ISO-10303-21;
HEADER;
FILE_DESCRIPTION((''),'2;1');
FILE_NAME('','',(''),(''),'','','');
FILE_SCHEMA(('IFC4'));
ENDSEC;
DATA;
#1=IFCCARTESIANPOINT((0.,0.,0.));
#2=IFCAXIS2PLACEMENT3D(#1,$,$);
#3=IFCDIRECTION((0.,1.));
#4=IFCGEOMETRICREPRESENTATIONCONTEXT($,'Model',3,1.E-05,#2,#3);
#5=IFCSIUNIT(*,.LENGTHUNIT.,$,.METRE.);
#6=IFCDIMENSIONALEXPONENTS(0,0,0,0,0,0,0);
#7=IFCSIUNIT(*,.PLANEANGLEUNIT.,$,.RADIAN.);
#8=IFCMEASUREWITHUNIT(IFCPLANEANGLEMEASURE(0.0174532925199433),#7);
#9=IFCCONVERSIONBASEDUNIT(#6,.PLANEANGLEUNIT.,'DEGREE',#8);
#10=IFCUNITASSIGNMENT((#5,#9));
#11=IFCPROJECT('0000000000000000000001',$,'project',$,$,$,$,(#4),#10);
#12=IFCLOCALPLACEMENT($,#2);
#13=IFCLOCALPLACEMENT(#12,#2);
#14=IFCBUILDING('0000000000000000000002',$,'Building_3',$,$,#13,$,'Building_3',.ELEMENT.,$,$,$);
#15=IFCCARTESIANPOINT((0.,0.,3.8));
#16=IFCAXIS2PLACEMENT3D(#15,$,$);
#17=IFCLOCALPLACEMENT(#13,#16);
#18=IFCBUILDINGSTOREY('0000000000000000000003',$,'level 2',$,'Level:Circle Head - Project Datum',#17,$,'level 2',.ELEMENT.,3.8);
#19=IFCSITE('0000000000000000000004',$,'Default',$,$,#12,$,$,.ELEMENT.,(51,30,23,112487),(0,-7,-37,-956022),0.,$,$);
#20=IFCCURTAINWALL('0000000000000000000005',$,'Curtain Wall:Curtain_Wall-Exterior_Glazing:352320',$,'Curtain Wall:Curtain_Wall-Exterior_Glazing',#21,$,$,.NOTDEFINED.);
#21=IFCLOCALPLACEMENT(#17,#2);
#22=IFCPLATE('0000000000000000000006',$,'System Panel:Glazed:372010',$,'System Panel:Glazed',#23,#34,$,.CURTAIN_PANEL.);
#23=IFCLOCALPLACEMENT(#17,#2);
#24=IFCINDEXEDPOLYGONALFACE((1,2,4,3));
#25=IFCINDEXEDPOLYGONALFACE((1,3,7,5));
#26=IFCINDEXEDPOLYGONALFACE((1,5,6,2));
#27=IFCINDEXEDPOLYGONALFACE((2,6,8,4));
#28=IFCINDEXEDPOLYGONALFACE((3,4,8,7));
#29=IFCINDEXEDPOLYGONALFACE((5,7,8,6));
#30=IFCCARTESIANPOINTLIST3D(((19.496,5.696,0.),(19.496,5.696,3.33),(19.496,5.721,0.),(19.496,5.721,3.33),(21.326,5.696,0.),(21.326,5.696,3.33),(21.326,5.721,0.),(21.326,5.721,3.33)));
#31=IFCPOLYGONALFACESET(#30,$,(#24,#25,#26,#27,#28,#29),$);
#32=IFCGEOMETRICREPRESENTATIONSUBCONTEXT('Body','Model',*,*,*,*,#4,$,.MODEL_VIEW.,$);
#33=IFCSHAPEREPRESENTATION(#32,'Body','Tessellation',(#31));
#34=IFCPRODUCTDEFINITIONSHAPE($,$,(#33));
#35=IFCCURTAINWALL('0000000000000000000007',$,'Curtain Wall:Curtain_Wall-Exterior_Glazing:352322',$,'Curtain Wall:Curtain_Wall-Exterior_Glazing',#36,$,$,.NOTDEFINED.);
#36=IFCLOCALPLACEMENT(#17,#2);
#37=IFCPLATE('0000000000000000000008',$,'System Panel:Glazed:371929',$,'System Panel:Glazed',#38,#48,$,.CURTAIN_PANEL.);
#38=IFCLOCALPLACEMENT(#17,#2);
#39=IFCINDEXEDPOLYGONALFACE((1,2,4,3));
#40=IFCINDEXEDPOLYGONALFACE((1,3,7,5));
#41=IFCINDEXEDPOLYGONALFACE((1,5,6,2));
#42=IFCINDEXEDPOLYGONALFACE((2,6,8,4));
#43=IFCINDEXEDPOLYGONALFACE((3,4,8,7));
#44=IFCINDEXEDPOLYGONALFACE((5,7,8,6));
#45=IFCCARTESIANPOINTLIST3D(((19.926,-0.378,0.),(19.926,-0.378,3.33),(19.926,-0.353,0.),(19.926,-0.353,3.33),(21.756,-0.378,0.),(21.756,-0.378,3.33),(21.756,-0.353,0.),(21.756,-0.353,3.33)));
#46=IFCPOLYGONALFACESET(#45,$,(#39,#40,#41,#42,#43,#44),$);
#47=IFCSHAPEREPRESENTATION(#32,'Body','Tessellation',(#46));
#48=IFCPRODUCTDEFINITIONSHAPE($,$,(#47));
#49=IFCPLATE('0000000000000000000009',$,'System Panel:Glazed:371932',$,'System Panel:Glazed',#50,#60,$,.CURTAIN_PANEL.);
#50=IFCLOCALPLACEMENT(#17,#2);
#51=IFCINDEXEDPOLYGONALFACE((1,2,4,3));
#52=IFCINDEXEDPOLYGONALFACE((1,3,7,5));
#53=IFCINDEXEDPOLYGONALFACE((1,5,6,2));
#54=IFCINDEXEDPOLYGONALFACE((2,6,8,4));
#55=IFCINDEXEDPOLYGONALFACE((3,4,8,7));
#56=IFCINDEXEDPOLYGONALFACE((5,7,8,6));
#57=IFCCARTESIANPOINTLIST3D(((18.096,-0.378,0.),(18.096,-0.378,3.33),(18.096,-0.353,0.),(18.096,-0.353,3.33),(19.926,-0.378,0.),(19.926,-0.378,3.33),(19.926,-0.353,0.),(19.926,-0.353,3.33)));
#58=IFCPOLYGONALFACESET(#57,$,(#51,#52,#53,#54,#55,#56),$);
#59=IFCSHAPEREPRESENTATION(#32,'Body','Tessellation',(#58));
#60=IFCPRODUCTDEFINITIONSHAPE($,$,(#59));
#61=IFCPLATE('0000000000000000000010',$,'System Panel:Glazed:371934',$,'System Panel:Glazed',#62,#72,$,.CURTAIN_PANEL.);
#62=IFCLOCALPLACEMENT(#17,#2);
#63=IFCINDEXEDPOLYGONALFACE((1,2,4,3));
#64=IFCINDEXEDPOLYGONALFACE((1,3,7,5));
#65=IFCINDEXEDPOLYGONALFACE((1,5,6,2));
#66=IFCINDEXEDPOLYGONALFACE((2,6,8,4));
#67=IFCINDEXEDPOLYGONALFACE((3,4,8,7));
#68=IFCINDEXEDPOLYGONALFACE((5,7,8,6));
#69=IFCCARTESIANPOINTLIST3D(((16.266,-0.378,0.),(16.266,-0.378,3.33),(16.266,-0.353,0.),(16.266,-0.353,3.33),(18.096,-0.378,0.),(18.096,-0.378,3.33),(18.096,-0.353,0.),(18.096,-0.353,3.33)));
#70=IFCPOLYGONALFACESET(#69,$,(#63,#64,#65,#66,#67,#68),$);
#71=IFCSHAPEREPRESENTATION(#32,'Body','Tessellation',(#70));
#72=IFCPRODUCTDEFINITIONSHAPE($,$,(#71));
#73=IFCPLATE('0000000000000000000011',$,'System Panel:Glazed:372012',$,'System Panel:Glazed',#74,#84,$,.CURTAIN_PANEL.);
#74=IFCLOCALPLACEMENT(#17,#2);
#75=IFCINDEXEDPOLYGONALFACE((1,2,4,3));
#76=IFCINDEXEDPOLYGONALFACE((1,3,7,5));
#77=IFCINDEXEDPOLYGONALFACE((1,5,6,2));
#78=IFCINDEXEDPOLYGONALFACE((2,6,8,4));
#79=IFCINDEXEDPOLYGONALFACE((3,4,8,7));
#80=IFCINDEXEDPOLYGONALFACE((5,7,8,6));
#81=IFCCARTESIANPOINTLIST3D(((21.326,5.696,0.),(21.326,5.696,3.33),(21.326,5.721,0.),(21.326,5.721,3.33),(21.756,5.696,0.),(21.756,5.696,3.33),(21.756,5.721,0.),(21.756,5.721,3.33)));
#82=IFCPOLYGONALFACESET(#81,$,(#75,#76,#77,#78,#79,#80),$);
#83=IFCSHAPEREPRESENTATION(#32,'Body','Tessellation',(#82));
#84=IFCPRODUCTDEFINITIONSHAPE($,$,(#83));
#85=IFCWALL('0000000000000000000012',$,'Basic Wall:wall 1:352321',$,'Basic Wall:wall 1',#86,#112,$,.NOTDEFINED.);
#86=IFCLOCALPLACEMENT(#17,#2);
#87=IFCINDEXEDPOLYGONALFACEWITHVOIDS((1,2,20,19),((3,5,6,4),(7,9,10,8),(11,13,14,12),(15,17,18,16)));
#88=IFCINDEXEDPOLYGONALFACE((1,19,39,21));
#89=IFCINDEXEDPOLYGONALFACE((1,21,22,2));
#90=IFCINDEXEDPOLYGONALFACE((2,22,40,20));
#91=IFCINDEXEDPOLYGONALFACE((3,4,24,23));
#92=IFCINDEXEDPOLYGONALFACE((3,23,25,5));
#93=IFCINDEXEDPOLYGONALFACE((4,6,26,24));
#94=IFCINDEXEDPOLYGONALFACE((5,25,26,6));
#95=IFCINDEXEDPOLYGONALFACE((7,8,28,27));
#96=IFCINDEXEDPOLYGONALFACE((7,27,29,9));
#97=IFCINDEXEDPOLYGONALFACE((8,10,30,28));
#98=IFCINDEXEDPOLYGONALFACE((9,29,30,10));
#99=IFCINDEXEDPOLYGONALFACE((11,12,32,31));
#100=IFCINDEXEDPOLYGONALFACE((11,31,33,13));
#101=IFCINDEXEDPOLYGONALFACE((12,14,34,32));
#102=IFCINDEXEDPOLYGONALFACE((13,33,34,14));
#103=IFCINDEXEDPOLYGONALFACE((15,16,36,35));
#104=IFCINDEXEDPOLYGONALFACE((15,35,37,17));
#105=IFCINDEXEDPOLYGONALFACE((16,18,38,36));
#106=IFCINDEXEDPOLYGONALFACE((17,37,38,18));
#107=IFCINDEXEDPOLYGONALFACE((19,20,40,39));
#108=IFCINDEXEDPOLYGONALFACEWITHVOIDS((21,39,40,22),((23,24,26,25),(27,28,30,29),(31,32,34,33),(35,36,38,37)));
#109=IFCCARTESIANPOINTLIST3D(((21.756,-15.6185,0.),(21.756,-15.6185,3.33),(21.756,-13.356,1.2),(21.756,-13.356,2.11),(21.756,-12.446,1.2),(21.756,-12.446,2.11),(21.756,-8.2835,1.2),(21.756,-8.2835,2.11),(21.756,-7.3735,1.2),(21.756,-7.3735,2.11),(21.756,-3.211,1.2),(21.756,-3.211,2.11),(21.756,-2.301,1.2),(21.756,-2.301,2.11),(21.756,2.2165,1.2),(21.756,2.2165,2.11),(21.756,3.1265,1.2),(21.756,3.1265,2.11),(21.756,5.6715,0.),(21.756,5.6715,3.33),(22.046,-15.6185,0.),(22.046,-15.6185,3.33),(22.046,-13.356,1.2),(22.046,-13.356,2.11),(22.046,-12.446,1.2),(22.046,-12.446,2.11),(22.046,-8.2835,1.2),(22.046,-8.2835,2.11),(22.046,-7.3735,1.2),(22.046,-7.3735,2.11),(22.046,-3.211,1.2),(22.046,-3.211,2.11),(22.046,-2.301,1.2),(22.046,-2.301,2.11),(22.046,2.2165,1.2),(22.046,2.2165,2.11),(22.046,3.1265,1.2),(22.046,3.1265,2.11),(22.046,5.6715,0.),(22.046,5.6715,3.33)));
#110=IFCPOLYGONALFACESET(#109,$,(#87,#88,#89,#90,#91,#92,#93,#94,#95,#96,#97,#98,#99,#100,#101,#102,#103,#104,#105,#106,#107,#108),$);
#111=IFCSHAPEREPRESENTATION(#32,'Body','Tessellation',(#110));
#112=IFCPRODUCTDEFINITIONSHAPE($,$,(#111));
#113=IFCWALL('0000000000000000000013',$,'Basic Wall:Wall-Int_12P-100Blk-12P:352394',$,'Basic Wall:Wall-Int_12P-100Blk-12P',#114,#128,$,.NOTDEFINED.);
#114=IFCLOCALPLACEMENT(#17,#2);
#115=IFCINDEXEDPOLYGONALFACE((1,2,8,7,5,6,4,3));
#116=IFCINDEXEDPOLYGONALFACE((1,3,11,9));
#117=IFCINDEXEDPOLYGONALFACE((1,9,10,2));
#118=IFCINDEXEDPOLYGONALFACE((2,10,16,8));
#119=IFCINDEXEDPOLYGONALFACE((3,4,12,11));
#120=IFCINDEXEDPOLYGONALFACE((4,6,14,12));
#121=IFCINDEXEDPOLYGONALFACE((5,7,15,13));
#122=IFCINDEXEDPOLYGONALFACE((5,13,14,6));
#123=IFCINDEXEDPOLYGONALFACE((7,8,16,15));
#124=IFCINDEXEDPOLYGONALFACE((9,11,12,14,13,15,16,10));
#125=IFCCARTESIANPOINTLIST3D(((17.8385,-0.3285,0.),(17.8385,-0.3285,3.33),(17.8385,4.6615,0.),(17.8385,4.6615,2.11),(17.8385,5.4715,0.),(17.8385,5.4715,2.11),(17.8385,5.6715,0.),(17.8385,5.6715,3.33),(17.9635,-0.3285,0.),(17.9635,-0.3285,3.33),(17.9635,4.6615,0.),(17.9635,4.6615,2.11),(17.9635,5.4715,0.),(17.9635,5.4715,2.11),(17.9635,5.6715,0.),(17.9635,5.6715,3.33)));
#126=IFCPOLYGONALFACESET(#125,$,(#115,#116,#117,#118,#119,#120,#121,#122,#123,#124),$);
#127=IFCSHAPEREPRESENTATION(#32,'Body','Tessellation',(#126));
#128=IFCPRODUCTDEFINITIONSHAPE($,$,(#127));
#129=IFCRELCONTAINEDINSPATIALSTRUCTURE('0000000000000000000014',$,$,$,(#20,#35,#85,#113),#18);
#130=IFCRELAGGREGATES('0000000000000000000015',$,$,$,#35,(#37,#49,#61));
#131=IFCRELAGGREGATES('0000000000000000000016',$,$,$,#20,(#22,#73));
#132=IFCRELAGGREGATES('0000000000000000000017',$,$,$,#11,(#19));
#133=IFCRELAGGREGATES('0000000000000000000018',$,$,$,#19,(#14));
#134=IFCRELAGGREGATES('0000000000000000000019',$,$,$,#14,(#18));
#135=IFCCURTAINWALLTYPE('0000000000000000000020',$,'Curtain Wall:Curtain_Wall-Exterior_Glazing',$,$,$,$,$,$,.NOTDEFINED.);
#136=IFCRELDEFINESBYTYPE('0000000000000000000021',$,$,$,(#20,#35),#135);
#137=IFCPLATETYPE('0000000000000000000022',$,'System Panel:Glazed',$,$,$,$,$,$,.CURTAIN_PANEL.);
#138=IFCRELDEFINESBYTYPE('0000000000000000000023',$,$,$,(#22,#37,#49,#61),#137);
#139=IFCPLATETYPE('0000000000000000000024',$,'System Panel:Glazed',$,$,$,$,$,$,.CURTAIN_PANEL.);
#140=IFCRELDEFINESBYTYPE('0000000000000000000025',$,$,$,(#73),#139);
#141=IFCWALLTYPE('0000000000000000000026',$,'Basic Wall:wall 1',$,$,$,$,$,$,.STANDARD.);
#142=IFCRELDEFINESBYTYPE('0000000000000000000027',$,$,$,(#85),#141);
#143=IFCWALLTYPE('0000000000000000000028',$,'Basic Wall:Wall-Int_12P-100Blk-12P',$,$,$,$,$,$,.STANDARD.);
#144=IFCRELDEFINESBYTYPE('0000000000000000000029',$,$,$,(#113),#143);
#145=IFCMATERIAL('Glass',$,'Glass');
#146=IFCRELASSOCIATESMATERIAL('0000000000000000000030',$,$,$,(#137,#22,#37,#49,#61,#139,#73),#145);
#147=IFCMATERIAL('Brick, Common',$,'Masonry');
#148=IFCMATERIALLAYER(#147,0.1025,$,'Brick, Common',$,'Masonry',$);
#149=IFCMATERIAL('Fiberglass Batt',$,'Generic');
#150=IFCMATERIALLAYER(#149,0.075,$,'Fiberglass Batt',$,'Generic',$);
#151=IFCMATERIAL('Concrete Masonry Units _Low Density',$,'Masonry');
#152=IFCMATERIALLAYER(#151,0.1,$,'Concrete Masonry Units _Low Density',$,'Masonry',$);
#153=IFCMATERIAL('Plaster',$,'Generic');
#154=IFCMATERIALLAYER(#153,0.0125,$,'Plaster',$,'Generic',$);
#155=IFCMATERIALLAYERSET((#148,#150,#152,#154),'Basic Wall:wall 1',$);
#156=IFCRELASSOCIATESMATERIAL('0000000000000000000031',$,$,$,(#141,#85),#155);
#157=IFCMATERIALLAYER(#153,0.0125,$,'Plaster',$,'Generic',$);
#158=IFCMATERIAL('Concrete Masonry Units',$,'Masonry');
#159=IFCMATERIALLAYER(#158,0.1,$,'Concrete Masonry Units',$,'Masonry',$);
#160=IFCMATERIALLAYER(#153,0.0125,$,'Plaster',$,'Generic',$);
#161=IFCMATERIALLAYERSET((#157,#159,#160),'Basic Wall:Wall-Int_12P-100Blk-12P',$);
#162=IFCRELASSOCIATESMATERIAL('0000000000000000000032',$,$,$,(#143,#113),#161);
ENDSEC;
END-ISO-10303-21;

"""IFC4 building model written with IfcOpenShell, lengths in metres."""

from ifc_helpers import new_model, entity, si_unit, converted_unit, direction, frame, frame_2d, origin, origin_2d_with_axis, place, context, subcontext, project, spatial, polyline, rectangle, extrude, clip, bounded_halfspace, source, transform, mapped, material, layer, layer_set, layer_usage, type_object, type_shapes, element, aggregate, save


model = new_model("IFC4")

# Units and contexts
model_context = context("Model", 3, precision=1e-05, world=origin(), true_north=direction((0.0, 1.0)))
body_context = subcontext(model_context, "Body", "Model", "MODEL_VIEW")
ifc_project = project(units=[si_unit("LENGTHUNIT", "METRE"), converted_unit("PLANEANGLEUNIT", "DEGREE", entity("IfcPlaneAngleMeasure", 0.0174532925199433), si_unit("PLANEANGLEUNIT", "RADIAN"), dimensions=[0, 0, 0, 0, 0, 0, 0])], contexts=[model_context])

# Site, building, storey
site_placement = place(None, origin())
site = spatial("IfcSite", under=ifc_project, at=site_placement, Name="Default", CompositionType="ELEMENT", RefLatitude=(51, 30, 23, 112487), RefLongitude=(0, -7, -37, -956022), RefElevation=0.0)
building_placement = place(site_placement, origin())
building = spatial("IfcBuilding", under=site, at=building_placement, Name="Building_3", LongName="Building_3", CompositionType="ELEMENT")
storey_placement = place(building_placement, frame((0.0, 0.0, 3.8)))
storey = spatial("IfcBuildingStorey", under=building, at=storey_placement, Name="level 2", ObjectType="Level:Circle Head - Project Datum", LongName="level 2", CompositionType="ELEMENT", Elevation=3.8)

# Curtain wall, plate
curtain_wall_type = type_object("IfcCurtainWallType", Name="Curtain Wall:Curtain_Wall-Exterior_Glazing", PredefinedType="NOTDEFINED")
curtain_wall_1_placement = place(storey_placement, frame((0.0, 0.0, -3.8)))
curtain_wall_1 = element("IfcCurtainWall", 1, at=curtain_wall_1_placement, inside=storey, type_object=curtain_wall_type, Name="Curtain Wall:Curtain_Wall-Exterior_Glazing:352320", ObjectType="Curtain Wall:Curtain_Wall-Exterior_Glazing", PredefinedType="NOTDEFINED")
ifc_material_1 = material(Name="Glass", Category="Glass")
plate_type_1 = type_object("IfcPlateType", Name="System Panel:Glazed", PredefinedType="CURTAIN_PANEL", material=ifc_material_1)
shared_shape_1 = source(origin(), body_context, "Body", "SweptSolid", [
    extrude(rectangle(XDim=0.025, YDim=1.83, at=origin_2d_with_axis()), frame((0.915, 0.0125, 0.0), z_axis=(0.0, 0.0, 1.0), x_axis=(0.0, 1.0, 0.0)), (0.0, 0.0, 1.0), 3.33),
])
type_shapes(plate_type_1, [shared_shape_1])
plate_1_placement = place(curtain_wall_1_placement, frame((19.496, 5.696, 3.8)))
plate_1 = element("IfcPlate", 2, at=plate_1_placement, type_object=plate_type_1, material=ifc_material_1, Name="System Panel:Glazed:372010", ObjectType="System Panel:Glazed", PredefinedType="CURTAIN_PANEL", context=body_context, shape_type="MappedRepresentation", body=[
    mapped(shared_shape_1, transform((0.0, 0.0, 0.0), scale=1.0)),
])

# Curtain wall, plates
curtain_wall_2_placement = place(storey_placement, frame((0.0, 0.0, -3.8)))
curtain_wall_2 = element("IfcCurtainWall", 3, at=curtain_wall_2_placement, inside=storey, type_object=curtain_wall_type, Name="Curtain Wall:Curtain_Wall-Exterior_Glazing:352322", ObjectType="Curtain Wall:Curtain_Wall-Exterior_Glazing", PredefinedType="NOTDEFINED")
plate_2_placement = place(curtain_wall_2_placement, frame((21.756, -0.353, 3.8), z_axis=(0.0, 0.0, 1.0), x_axis=(-1.0, 0.0, 0.0)))
plate_2 = element("IfcPlate", 4, at=plate_2_placement, type_object=plate_type_1, material=ifc_material_1, Name="System Panel:Glazed:371929", ObjectType="System Panel:Glazed", PredefinedType="CURTAIN_PANEL", context=body_context, shape_type="MappedRepresentation", body=[
    mapped(shared_shape_1, transform((0.0, 0.0, 0.0), scale=1.0)),
])
plate_3_placement = place(curtain_wall_2_placement, frame((19.926, -0.353, 3.8), z_axis=(0.0, 0.0, 1.0), x_axis=(-1.0, 0.0, 0.0)))
plate_3 = element("IfcPlate", 5, at=plate_3_placement, type_object=plate_type_1, material=ifc_material_1, Name="System Panel:Glazed:371932", ObjectType="System Panel:Glazed", PredefinedType="CURTAIN_PANEL", context=body_context, shape_type="MappedRepresentation", body=[
    mapped(shared_shape_1, transform((0.0, 0.0, 0.0), scale=1.0)),
])
plate_4_placement = place(curtain_wall_2_placement, frame((18.096, -0.353, 3.8), z_axis=(0.0, 0.0, 1.0), x_axis=(-1.0, 0.0, 0.0)))
plate_4 = element("IfcPlate", 6, at=plate_4_placement, type_object=plate_type_1, material=ifc_material_1, Name="System Panel:Glazed:371934", ObjectType="System Panel:Glazed", PredefinedType="CURTAIN_PANEL", context=body_context, shape_type="MappedRepresentation", body=[
    mapped(shared_shape_1, transform((0.0, 0.0, 0.0), scale=1.0)),
])
aggregate(curtain_wall_2, [plate_2, plate_3, plate_4])

# Plate
plate_type_2 = type_object("IfcPlateType", Name="System Panel:Glazed", PredefinedType="CURTAIN_PANEL", material=ifc_material_1)
shared_shape_2 = source(origin(), body_context, "Body", "SweptSolid", [
    extrude(rectangle(XDim=0.025, YDim=0.43, at=origin_2d_with_axis()), frame((0.215, 0.0125, 0.0), z_axis=(0.0, 0.0, 1.0), x_axis=(0.0, 1.0, 0.0)), (0.0, 0.0, 1.0), 3.33),
])
type_shapes(plate_type_2, [shared_shape_2])
plate_5_placement = place(curtain_wall_1_placement, frame((21.326, 5.696, 3.8)))
plate_5 = element("IfcPlate", 7, at=plate_5_placement, type_object=plate_type_2, material=ifc_material_1, Name="System Panel:Glazed:372012", ObjectType="System Panel:Glazed", PredefinedType="CURTAIN_PANEL", context=body_context, shape_type="MappedRepresentation", body=[
    mapped(shared_shape_2, transform((0.0, 0.0, 0.0), scale=1.0)),
])
aggregate(curtain_wall_1, [plate_1, plate_5])

# Wall, openings
ifc_material_2 = material(Name="Brick, Common", Category="Masonry")
ifc_layer_1 = layer(ifc_material_2, 0.1025, Name="Brick, Common", Category="Masonry")
ifc_material_3 = material(Name="Fiberglass Batt", Category="Generic")
ifc_layer_2 = layer(ifc_material_3, 0.075, Name="Fiberglass Batt", Category="Generic")
ifc_material_4 = material(Name="Concrete Masonry Units _Low Density", Category="Masonry")
ifc_layer_3 = layer(ifc_material_4, 0.1, Name="Concrete Masonry Units _Low Density", Category="Masonry")
ifc_material_5 = material(Name="Plaster", Category="Generic")
ifc_layer_4 = layer(ifc_material_5, 0.0125, Name="Plaster", Category="Generic")
ifc_layer_set_1 = layer_set([ifc_layer_1, ifc_layer_2, ifc_layer_3, ifc_layer_4], Name="Basic Wall:wall 1")
ifc_layer_usage_1 = layer_usage(ifc_layer_set_1, "AXIS2", "NEGATIVE", 0.145)
wall_type_1 = type_object("IfcWallType", Name="Basic Wall:wall 1", PredefinedType="STANDARD", material=ifc_layer_set_1)
wall_1_placement = place(storey_placement, frame((21.901, 5.6715, 0.0), z_axis=(0.0, 0.0, 1.0), x_axis=(0.0, -1.0, 0.0)))
wall_1 = element("IfcWall", 8, at=wall_1_placement, inside=storey, type_object=wall_type_1, material=ifc_layer_usage_1, Name="Basic Wall:wall 1:352321", ObjectType="Basic Wall:wall 1", PredefinedType="NOTDEFINED", context=body_context, shape_type="Clipping", body=[
    clip(extrude(rectangle(XDim=21.29, YDim=0.29, at=frame_2d((10.645, 0.0), x_axis=(-1.0, 0.0))), origin(), (0.0, 0.0, 1.0), 3.33), bounded_halfspace(frame((0.0, -0.145, 3.33), z_axis=(0.0, 0.0, -1.0), x_axis=(-1.0, 0.0, 0.0)), True, frame((0.0, -0.145, 3.33)), polyline([(0.0, 0.0), (10.9375, 0.0), (11.0625, 0.0), (15.9375, 0.0), (16.0625, 0.0), (21.0, 0.0), (21.29, 0.0), (21.29, 0.29), (0.0, 0.29), (0.0, 0.0)]))),
])
opening_1_placement = place(wall_1_placement, frame((5.6715, -21.901, 0.0)))
element("IfcOpeningElement", 9, at=opening_1_placement, cuts=wall_1, PredefinedType="OPENING", context=body_context, shape_type="SweptSolid", body=[
    extrude(rectangle(XDim=2.11, YDim=0.125, at=frame_2d((0.0, 0.0), x_axis=(0.0, 1.0))), frame((5.3285, 20.946, 1.055), z_axis=(0.0, 1.0, 0.0), x_axis=(1.0, 0.0, 0.0)), (0.0, 0.0, 1.0), 0.81),
])
opening_2_placement = place(wall_1_placement, frame((5.6715, -21.901, 0.0)))
element("IfcOpeningElement", 10, at=opening_2_placement, cuts=wall_1, PredefinedType="OPENING", context=body_context, shape_type="SweptSolid", body=[
    extrude(rectangle(XDim=2.11, YDim=0.125, at=frame_2d((0.0, 0.0), x_axis=(0.0, 1.0))), frame((10.3285, 20.946, 1.055), z_axis=(0.0, 1.0, 0.0), x_axis=(1.0, 0.0, 0.0)), (0.0, 0.0, 1.0), 0.81),
])
opening_3_placement = place(wall_1_placement, frame((2.545, -0.145, 1.2)))
element("IfcOpeningElement", 11, at=opening_3_placement, cuts=wall_1, PredefinedType="OPENING", context=body_context, shape_type="SweptSolid", body=[
    extrude(rectangle(XDim=0.91, YDim=0.91, at=frame_2d((0.455, 0.455), x_axis=(-1.0, 0.0))), frame((0.0, 0.0, 0.0), z_axis=(0.0, 1.0, 0.0), x_axis=(0.0, 0.0, 1.0)), (0.0, 0.0, 1.0), 0.29),
])
opening_4_placement = place(wall_1_placement, frame((7.9725, -0.145, 1.2)))
element("IfcOpeningElement", 12, at=opening_4_placement, cuts=wall_1, PredefinedType="OPENING", context=body_context, shape_type="SweptSolid", body=[
    extrude(rectangle(XDim=0.91, YDim=0.91, at=frame_2d((0.455, 0.455), x_axis=(-1.0, 0.0))), frame((0.0, 0.0, 0.0), z_axis=(0.0, 1.0, 0.0), x_axis=(0.0, 0.0, 1.0)), (0.0, 0.0, 1.0), 0.29),
])
opening_5_placement = place(wall_1_placement, frame((13.045, -0.145, 1.2)))
element("IfcOpeningElement", 13, at=opening_5_placement, cuts=wall_1, PredefinedType="OPENING", context=body_context, shape_type="SweptSolid", body=[
    extrude(rectangle(XDim=0.91, YDim=0.91, at=frame_2d((0.455, 0.455), x_axis=(-1.0, 0.0))), frame((0.0, 0.0, 0.0), z_axis=(0.0, 1.0, 0.0), x_axis=(0.0, 0.0, 1.0)), (0.0, 0.0, 1.0), 0.29),
])
opening_6_placement = place(wall_1_placement, frame((18.1175, -0.145, 1.2)))
element("IfcOpeningElement", 14, at=opening_6_placement, cuts=wall_1, PredefinedType="OPENING", context=body_context, shape_type="SweptSolid", body=[
    extrude(rectangle(XDim=0.91, YDim=0.91, at=frame_2d((0.455, 0.455), x_axis=(-1.0, 0.0))), frame((0.0, 0.0, 0.0), z_axis=(0.0, 1.0, 0.0), x_axis=(0.0, 0.0, 1.0)), (0.0, 0.0, 1.0), 0.29),
])

# Wall, opening
ifc_layer_5 = layer(ifc_material_5, 0.0125, Name="Plaster", Category="Generic")
ifc_material_6 = material(Name="Concrete Masonry Units", Category="Masonry")
ifc_layer_6 = layer(ifc_material_6, 0.1, Name="Concrete Masonry Units", Category="Masonry")
ifc_layer_7 = layer(ifc_material_5, 0.0125, Name="Plaster", Category="Generic")
ifc_layer_set_2 = layer_set([ifc_layer_5, ifc_layer_6, ifc_layer_7], Name="Basic Wall:Wall-Int_12P-100Blk-12P")
ifc_layer_usage_2 = layer_usage(ifc_layer_set_2, "AXIS2", "NEGATIVE", 0.0625)
wall_type_2 = type_object("IfcWallType", Name="Basic Wall:Wall-Int_12P-100Blk-12P", PredefinedType="STANDARD", material=ifc_layer_set_2)
wall_2_placement = place(storey_placement, frame((17.901, 5.6715, 0.0), z_axis=(0.0, 0.0, 1.0), x_axis=(0.0, -1.0, 0.0)))
wall_2 = element("IfcWall", 15, at=wall_2_placement, inside=storey, type_object=wall_type_2, material=ifc_layer_usage_2, Name="Basic Wall:Wall-Int_12P-100Blk-12P:352394", ObjectType="Basic Wall:Wall-Int_12P-100Blk-12P", PredefinedType="NOTDEFINED", context=body_context, shape_type="Clipping", body=[
    clip(extrude(rectangle(XDim=6.0, YDim=0.125, at=frame_2d((3.0, 0.0), x_axis=(-1.0, 0.0))), origin(), (0.0, 0.0, 1.0), 3.33), bounded_halfspace(frame((0.0, -0.0625, 3.33), z_axis=(0.0, 0.0, -1.0), x_axis=(-1.0, 0.0, 0.0)), True, frame((0.0, -0.0625, 3.33)), polyline([(0.0, 0.0), (6.0, 0.0), (6.0, 0.125), (0.0, 0.125), (0.0, 0.0)]))),
])
opening_7_placement = place(wall_2_placement, frame((0.2, -0.0625, 0.0)))
element("IfcOpeningElement", 16, at=opening_7_placement, cuts=wall_2, PredefinedType="OPENING", context=body_context, shape_type="SweptSolid", body=[
    extrude(rectangle(XDim=2.11, YDim=0.81, at=frame_2d((1.055, 0.405), x_axis=(1.0, 0.0))), frame((0.0, 0.0, 0.0), z_axis=(0.0, 1.0, 0.0), x_axis=(0.0, 0.0, 1.0)), (0.0, 0.0, 1.0), 0.125),
])

save(model, "model.ifc")
